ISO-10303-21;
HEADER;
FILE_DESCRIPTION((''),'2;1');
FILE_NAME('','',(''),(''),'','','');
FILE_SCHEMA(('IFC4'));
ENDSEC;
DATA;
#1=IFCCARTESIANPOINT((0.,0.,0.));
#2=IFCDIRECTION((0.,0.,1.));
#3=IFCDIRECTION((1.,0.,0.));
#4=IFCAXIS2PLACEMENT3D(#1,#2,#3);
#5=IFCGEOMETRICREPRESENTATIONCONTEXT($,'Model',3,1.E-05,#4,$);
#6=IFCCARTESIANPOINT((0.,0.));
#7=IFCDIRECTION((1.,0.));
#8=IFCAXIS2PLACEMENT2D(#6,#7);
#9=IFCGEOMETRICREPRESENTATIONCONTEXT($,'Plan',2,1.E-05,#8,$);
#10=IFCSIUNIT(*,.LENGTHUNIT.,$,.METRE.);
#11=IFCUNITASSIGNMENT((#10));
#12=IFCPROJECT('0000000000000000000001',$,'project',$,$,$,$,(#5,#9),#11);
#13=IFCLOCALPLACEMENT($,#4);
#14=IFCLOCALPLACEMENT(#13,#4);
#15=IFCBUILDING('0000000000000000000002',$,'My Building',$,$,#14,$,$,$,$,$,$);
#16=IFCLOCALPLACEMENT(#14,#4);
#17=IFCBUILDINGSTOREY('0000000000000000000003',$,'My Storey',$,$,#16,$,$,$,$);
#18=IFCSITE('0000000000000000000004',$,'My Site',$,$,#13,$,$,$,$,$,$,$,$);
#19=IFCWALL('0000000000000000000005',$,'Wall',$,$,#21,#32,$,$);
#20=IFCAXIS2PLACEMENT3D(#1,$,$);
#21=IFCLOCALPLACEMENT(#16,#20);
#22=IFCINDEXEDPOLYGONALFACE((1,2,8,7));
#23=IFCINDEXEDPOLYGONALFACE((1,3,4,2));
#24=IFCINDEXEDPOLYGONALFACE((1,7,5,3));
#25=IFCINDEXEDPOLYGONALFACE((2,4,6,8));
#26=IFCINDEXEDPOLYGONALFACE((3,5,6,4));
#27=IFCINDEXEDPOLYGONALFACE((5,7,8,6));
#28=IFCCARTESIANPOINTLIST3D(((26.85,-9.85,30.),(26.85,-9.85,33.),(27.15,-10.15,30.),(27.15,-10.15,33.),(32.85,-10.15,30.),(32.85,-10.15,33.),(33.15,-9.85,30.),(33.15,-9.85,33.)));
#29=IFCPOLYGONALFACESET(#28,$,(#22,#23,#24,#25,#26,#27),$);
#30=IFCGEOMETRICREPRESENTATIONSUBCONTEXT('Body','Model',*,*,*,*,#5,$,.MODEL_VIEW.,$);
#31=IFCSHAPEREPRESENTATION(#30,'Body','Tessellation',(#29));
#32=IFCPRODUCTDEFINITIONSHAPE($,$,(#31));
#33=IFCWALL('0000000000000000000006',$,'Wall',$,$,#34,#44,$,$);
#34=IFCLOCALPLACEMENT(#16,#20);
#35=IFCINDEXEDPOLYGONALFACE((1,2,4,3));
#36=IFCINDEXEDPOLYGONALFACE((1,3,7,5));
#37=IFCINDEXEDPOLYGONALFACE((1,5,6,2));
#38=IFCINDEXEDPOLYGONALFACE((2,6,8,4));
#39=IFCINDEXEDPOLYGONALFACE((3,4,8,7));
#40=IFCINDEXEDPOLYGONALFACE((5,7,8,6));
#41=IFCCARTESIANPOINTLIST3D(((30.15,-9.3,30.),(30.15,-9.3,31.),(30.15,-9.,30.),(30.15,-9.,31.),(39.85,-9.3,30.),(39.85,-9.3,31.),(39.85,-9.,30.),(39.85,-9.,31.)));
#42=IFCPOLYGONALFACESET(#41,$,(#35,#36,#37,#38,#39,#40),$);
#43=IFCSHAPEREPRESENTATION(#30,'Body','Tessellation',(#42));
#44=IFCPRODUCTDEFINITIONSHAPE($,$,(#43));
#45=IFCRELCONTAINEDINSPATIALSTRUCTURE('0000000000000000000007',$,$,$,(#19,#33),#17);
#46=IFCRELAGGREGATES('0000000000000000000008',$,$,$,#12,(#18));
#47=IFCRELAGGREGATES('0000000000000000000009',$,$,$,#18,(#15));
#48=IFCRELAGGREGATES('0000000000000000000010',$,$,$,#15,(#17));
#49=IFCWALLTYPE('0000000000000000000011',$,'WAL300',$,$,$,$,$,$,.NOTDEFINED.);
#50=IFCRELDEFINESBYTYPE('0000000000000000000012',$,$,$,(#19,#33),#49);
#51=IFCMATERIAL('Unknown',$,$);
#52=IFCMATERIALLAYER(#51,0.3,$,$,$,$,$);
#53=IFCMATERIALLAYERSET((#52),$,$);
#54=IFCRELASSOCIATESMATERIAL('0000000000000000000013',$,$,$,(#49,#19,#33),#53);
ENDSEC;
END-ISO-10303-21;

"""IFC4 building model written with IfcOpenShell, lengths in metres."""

from ifc_helpers import new_model, si_unit, frame, origin_with_axes, origin_2d_with_axis, place, context, subcontext, project, spatial, line, indexed_curve, outline, extrude, material, layer, layer_set, layer_usage, type_object, element, save


model = new_model("IFC4")

# Units and contexts
model_context = context("Model", 3, precision=1e-05, world=origin_with_axes())
plan_context = context("Plan", 2, precision=1e-05, world=origin_2d_with_axis())
body_context = subcontext(model_context, "Body", "Model", "MODEL_VIEW")
ifc_project = project(units=[si_unit("LENGTHUNIT", "METRE")], contexts=[model_context, plan_context])

# Site, building, storey
site_placement = place(None, origin_with_axes())
site = spatial("IfcSite", under=ifc_project, at=site_placement, Name="My Site")
building_placement = place(site_placement, origin_with_axes())
building = spatial("IfcBuilding", under=site, at=building_placement, Name="My Building")
storey_placement = place(building_placement, origin_with_axes())
storey = spatial("IfcBuildingStorey", under=building, at=storey_placement, Name="My Storey")

# Shared definitions
ifc_material = material(Name="Unknown")

# Walls
ifc_layer_1 = layer(ifc_material, 0.3)
ifc_layer_set_1 = layer_set([ifc_layer_1])
wall_type = type_object("IfcWallType", Name="WAL300", PredefinedType="NOTDEFINED", material=ifc_layer_set_1)
ifc_layer_usage_1 = layer_usage(ifc_layer_set_1, "AXIS2", "POSITIVE", -0.15)
wall_1_placement = place(storey_placement, frame((27.0, -10.0, 30.0), z_axis=(0.0, 0.0, 1.0), x_axis=(1.0, 0.0, 0.0)))
element("IfcWall", 1, at=wall_1_placement, inside=storey, type_object=wall_type, material=ifc_layer_usage_1, Name="Wall", context=body_context, shape_type="SweptSolid", body=[
    extrude(outline(indexed_curve([(0.15, -0.15), (-0.15, 0.15), (6.15, 0.15), (5.85, -0.15)], segments=[line(1, 2, 3, 4, 1)])), origin_with_axes(), (0.0, 0.0, 1.0), 3.0),
])
ifc_layer_usage_2 = layer_usage(ifc_layer_set_1, "AXIS2", "POSITIVE", -0.3)
wall_2_placement = place(storey_placement, frame((30.15, -9.0, 30.0), z_axis=(0.0, 0.0, 1.0), x_axis=(1.0, 0.0, 0.0)))
element("IfcWall", 2, at=wall_2_placement, inside=storey, type_object=wall_type, material=ifc_layer_usage_2, Name="Wall", context=body_context, shape_type="SweptSolid", body=[
    extrude(outline(indexed_curve([(0.0, -0.3), (0.0, 0.0), (9.7, 0.0), (9.7, -0.3)], segments=[line(1, 2, 3, 4, 1)])), origin_with_axes(), (0.0, 0.0, 1.0), 1.0),
])

save(model, "model.ifc")
